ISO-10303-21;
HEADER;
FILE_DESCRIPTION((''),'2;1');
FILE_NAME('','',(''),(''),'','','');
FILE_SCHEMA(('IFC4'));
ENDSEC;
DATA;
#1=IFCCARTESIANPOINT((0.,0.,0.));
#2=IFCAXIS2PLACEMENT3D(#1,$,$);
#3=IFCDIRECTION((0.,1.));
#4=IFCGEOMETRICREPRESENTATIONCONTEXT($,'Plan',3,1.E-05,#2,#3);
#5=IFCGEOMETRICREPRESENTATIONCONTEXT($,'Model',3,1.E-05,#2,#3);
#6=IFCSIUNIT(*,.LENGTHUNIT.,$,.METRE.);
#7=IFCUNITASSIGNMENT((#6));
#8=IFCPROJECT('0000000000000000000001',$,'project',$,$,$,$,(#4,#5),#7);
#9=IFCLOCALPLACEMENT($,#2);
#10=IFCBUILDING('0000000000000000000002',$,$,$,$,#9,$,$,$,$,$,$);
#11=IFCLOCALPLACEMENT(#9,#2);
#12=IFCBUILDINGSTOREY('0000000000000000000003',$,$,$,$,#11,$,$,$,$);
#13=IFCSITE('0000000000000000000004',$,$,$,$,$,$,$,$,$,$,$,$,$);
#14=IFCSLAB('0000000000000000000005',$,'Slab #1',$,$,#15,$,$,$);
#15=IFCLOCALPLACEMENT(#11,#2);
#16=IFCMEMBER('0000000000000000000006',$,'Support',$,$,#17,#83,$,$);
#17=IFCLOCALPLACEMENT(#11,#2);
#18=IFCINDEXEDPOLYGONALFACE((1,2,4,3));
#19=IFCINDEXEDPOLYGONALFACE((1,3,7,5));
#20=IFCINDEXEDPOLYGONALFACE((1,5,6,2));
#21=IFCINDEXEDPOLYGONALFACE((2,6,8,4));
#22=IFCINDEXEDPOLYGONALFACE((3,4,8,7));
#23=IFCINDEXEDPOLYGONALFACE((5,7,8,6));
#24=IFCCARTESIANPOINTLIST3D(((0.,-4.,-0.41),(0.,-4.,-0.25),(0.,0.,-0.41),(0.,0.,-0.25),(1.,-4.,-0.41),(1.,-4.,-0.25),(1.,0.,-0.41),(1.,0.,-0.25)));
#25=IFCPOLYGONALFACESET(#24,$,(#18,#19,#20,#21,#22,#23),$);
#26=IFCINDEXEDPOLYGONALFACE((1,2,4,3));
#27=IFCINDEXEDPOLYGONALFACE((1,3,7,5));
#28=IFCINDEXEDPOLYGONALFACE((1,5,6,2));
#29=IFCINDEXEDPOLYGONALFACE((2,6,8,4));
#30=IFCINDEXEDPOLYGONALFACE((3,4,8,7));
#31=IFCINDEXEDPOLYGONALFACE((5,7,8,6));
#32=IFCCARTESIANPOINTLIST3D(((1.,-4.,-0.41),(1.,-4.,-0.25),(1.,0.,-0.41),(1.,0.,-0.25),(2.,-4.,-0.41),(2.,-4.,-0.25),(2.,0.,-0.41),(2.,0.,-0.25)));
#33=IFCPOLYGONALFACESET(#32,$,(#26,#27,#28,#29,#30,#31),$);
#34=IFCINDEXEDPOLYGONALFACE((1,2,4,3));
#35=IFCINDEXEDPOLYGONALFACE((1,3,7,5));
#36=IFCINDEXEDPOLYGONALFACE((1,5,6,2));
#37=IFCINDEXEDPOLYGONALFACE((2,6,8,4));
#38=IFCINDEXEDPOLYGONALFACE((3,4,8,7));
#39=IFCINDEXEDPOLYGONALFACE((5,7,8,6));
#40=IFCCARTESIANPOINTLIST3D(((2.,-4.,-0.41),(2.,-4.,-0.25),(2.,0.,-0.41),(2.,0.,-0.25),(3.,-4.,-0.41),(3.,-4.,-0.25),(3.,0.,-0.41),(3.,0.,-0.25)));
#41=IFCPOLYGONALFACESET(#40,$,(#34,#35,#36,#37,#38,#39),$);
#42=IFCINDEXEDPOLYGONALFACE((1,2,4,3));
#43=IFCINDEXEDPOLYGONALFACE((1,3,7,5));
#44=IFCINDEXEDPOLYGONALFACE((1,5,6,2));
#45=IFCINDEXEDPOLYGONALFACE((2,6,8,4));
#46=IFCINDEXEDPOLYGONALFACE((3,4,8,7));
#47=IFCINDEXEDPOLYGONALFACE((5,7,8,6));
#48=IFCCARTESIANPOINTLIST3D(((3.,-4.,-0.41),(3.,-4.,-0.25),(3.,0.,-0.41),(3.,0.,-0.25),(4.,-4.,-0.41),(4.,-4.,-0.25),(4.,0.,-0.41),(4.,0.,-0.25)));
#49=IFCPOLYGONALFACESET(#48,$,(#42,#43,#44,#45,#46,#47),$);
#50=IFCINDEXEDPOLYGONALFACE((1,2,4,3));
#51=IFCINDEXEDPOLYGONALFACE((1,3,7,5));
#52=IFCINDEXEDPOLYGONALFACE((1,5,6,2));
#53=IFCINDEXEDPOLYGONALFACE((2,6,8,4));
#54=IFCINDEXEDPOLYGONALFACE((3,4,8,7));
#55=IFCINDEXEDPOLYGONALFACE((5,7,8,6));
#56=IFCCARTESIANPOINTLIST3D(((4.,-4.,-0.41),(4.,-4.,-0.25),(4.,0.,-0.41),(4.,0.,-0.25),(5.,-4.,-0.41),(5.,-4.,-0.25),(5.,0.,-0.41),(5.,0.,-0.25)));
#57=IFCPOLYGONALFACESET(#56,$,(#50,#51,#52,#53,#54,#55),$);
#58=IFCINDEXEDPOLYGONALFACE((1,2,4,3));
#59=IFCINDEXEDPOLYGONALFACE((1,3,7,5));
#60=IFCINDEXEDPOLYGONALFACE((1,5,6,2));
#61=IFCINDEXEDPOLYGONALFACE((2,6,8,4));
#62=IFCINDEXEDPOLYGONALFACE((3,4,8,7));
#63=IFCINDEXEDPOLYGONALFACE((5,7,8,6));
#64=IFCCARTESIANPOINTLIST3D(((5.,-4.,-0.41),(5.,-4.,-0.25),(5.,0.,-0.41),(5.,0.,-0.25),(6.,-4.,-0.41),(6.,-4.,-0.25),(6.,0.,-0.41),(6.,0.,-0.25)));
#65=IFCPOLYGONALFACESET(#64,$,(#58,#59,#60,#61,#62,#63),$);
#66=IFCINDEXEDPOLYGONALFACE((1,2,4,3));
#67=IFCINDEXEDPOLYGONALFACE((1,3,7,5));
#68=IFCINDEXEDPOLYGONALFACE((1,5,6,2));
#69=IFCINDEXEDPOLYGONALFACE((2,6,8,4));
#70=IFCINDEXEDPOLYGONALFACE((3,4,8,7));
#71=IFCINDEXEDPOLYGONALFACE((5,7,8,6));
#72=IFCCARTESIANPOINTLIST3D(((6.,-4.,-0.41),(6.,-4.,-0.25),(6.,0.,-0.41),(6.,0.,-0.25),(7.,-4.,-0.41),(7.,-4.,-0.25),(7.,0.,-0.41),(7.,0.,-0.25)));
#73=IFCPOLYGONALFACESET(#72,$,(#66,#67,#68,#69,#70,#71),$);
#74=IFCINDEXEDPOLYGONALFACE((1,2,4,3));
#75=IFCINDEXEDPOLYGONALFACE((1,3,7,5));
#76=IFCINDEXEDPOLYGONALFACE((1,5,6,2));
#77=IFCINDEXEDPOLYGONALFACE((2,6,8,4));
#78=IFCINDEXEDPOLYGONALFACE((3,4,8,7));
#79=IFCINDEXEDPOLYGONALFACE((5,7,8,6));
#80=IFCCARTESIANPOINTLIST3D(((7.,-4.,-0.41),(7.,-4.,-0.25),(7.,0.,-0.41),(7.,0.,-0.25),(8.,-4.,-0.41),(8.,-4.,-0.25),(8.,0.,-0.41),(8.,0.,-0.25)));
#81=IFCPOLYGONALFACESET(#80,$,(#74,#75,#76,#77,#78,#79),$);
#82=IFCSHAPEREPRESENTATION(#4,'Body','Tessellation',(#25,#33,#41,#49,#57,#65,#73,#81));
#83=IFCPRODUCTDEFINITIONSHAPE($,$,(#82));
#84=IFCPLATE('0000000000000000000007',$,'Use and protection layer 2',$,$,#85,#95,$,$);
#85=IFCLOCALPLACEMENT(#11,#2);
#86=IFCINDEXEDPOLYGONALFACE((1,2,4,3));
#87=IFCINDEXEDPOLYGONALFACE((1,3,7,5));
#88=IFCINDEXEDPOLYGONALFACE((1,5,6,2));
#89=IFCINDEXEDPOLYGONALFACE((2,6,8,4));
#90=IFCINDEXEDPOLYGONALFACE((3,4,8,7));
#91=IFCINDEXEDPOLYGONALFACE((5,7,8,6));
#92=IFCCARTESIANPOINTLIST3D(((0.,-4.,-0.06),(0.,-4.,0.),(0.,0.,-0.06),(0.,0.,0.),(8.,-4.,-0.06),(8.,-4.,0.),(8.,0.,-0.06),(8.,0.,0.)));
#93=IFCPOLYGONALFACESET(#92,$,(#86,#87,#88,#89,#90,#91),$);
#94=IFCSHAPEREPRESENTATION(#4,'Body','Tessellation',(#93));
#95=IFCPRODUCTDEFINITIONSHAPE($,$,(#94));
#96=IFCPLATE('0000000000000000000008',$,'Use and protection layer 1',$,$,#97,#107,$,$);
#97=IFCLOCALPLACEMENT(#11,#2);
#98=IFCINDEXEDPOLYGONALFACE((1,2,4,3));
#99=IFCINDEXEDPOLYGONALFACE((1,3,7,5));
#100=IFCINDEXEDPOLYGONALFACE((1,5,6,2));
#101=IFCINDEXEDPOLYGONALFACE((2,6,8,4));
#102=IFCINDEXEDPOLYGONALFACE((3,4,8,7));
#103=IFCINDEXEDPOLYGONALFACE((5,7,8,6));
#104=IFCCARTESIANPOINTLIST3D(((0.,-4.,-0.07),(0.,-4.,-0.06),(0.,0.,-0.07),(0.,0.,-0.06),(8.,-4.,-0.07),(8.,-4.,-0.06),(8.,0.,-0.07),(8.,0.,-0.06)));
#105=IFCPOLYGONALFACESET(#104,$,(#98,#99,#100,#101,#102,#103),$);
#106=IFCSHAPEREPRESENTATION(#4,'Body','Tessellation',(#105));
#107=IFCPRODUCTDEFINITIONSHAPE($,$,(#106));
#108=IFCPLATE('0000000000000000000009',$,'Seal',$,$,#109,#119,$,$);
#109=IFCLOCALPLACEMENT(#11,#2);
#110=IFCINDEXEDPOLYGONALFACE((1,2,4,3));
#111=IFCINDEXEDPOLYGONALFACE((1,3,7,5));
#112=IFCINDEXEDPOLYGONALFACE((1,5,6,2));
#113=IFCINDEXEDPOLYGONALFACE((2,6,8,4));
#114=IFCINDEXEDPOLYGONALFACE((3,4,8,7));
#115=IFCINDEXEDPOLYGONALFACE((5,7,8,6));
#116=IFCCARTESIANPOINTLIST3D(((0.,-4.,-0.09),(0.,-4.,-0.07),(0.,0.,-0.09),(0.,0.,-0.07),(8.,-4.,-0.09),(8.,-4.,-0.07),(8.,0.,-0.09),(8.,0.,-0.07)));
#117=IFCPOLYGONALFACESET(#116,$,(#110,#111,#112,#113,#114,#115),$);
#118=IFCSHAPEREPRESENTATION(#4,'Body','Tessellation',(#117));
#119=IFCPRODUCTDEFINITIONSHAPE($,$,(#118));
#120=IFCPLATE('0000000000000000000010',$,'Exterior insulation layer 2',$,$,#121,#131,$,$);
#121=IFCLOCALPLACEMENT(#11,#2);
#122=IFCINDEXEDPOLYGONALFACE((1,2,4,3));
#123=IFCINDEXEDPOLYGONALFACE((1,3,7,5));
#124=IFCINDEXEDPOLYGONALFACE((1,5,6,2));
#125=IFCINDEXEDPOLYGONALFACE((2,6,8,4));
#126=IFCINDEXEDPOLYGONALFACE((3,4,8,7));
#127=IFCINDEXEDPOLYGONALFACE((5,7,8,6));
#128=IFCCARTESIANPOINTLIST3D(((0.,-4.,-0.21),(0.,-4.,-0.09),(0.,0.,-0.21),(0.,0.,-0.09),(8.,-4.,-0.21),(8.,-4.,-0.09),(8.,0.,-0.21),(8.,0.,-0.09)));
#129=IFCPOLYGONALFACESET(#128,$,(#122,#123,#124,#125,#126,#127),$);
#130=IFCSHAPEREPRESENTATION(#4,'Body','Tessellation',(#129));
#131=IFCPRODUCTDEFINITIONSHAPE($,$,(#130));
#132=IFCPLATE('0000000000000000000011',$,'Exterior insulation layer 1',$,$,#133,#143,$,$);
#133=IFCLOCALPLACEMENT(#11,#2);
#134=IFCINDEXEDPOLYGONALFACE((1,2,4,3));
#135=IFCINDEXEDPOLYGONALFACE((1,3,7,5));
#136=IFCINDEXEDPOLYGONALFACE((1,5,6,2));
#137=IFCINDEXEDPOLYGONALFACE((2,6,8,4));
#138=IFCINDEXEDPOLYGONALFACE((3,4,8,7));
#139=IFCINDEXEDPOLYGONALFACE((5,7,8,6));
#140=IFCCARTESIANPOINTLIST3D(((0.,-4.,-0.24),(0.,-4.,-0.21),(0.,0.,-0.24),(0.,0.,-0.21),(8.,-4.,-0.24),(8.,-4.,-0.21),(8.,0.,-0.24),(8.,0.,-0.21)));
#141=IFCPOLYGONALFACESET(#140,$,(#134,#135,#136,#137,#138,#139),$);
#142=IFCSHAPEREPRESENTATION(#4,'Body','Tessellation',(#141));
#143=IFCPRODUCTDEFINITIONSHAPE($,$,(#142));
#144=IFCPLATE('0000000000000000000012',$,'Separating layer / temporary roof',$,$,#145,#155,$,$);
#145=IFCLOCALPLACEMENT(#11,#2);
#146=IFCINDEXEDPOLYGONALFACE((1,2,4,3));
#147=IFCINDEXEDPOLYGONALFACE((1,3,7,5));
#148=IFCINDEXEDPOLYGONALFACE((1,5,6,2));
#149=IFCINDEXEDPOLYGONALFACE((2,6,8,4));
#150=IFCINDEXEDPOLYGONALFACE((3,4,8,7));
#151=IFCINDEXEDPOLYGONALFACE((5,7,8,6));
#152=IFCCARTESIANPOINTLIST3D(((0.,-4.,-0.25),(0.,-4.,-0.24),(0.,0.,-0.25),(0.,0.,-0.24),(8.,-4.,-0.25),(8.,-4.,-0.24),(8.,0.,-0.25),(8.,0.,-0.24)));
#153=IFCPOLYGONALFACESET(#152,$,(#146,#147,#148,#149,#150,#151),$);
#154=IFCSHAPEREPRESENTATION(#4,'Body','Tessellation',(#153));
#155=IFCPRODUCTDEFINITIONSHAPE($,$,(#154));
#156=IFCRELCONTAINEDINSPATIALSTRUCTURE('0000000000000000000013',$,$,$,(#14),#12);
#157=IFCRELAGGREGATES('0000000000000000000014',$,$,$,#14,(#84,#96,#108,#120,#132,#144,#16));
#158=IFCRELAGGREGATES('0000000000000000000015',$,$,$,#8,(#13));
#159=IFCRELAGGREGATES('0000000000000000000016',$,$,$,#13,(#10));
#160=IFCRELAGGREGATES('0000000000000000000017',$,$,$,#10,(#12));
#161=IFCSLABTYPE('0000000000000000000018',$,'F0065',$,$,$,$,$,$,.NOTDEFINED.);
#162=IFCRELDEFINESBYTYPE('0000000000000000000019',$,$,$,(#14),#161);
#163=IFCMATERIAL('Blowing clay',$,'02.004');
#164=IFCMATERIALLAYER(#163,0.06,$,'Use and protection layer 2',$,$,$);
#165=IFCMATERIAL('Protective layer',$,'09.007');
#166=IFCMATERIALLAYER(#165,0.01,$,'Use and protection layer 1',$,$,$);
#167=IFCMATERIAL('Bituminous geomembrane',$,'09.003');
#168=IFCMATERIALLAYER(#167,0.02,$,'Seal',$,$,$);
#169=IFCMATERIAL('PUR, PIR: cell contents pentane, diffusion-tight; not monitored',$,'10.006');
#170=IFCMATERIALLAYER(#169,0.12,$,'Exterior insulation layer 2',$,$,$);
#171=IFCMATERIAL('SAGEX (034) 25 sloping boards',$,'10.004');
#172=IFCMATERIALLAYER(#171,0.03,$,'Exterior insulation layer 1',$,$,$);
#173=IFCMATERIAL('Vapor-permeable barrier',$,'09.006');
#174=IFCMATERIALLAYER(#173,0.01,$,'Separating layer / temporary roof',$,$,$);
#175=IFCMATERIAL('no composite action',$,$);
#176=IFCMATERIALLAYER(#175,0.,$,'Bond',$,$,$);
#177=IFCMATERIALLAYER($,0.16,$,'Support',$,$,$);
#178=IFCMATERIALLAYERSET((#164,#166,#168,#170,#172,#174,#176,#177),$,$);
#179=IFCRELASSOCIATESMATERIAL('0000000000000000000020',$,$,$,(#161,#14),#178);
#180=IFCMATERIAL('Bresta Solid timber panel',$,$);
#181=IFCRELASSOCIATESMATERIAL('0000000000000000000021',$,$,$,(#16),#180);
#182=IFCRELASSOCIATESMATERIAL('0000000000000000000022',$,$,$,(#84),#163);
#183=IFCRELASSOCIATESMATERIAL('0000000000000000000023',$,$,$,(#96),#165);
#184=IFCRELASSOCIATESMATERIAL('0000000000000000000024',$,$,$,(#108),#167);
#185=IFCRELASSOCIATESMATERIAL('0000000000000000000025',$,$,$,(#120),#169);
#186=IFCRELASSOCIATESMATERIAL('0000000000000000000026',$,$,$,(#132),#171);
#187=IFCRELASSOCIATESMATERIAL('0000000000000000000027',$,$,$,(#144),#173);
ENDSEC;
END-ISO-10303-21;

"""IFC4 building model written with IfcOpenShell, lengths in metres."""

from ifc_helpers import new_model, si_unit, direction, frame, frame_2d, origin, origin_with_axes, place, context, project, spatial, rectangle, extrude, material, layer, layer_set, type_object, element, aggregate, save


model = new_model("IFC4")

# Units and contexts
plan_context = context("Plan", 3, precision=1e-05, world=origin(), true_north=direction((0.0, 1.0)))
model_context = context("Model", 3, precision=1e-05, world=origin(), true_north=direction((0.0, 1.0)))
ifc_project = project(units=[si_unit("LENGTHUNIT", "METRE")], contexts=[plan_context, model_context])

# Site, building, storey
site = spatial("IfcSite", under=ifc_project)
building_placement = place(None, origin())
building = spatial("IfcBuilding", under=site, at=building_placement)
storey_placement = place(building_placement, origin())
storey = spatial("IfcBuildingStorey", under=building, at=storey_placement)

# Slab, member, plates
ifc_material_1 = material(Name="Blowing clay", Category="02.004")
ifc_layer_1 = layer(ifc_material_1, 0.06, Name="Use and protection layer 2")
ifc_material_2 = material(Name="Protective layer", Category="09.007")
ifc_layer_2 = layer(ifc_material_2, 0.01, Name="Use and protection layer 1")
ifc_material_3 = material(Name="Bituminous geomembrane", Category="09.003")
ifc_layer_3 = layer(ifc_material_3, 0.02, Name="Seal")
ifc_material_4 = material(Name="PUR, PIR: cell contents pentane, diffusion-tight; not monitored", Category="10.006")
ifc_layer_4 = layer(ifc_material_4, 0.12, Name="Exterior insulation layer 2")
ifc_material_5 = material(Name="SAGEX (034) 25 sloping boards", Category="10.004")
ifc_layer_5 = layer(ifc_material_5, 0.03, Name="Exterior insulation layer 1")
ifc_material_6 = material(Name="Vapor-permeable barrier", Category="09.006")
ifc_layer_6 = layer(ifc_material_6, 0.01, Name="Separating layer / temporary roof")
ifc_material_7 = material(Name="no composite action")
ifc_layer_7 = layer(ifc_material_7, 0.0, Name="Bond")
ifc_layer_8 = layer(None, 0.16, Name="Support")
ifc_layer_set = layer_set([ifc_layer_1, ifc_layer_2, ifc_layer_3, ifc_layer_4, ifc_layer_5, ifc_layer_6, ifc_layer_7, ifc_layer_8])
slab_type = type_object("IfcSlabType", Name="F0065", PredefinedType="NOTDEFINED", material=ifc_layer_set)
slab_placement = place(None, frame((0.0, 0.0, 0.0), z_axis=(0.0, 0.0, -1.0), x_axis=(1.0, 0.0, 0.0)))
slab = element("IfcSlab", 1, at=slab_placement, inside=storey, type_object=slab_type, material=ifc_layer_set, Name="Slab #1")
ifc_material_8 = material(Name="Bresta Solid timber panel")
member_placement = place(slab_placement, origin())
member = element("IfcMember", 2, at=member_placement, material=ifc_material_8, Name="Support", context=plan_context, shape_type="SweptSolid", body=[
    extrude(rectangle(XDim=1.0, YDim=0.16, at=frame_2d((0.5, 0.08), x_axis=(1.0, 0.0))), frame((0.0, 4.0, 0.25), z_axis=(0.0, -1.0, 0.0), x_axis=(1.0, 0.0, 0.0)), (0.0, 0.0, 1.0), 4.0),
    extrude(rectangle(XDim=1.0, YDim=0.16, at=frame_2d((0.5, 0.08), x_axis=(1.0, 0.0))), frame((1.0, 4.0, 0.25), z_axis=(0.0, -1.0, 0.0), x_axis=(1.0, 0.0, 0.0)), (0.0, 0.0, 1.0), 4.0),
    extrude(rectangle(XDim=1.0, YDim=0.16, at=frame_2d((0.5, 0.08), x_axis=(1.0, 0.0))), frame((2.0, 4.0, 0.25), z_axis=(0.0, -1.0, 0.0), x_axis=(1.0, 0.0, 0.0)), (0.0, 0.0, 1.0), 4.0),
    extrude(rectangle(XDim=1.0, YDim=0.16, at=frame_2d((0.5, 0.08), x_axis=(1.0, 0.0))), frame((3.0, 4.0, 0.25), z_axis=(0.0, -1.0, 0.0), x_axis=(1.0, 0.0, 0.0)), (0.0, 0.0, 1.0), 4.0),
    extrude(rectangle(XDim=1.0, YDim=0.16, at=frame_2d((0.5, 0.08), x_axis=(1.0, 0.0))), frame((4.0, 4.0, 0.25), z_axis=(0.0, -1.0, 0.0), x_axis=(1.0, 0.0, 0.0)), (0.0, 0.0, 1.0), 4.0),
    extrude(rectangle(XDim=1.0, YDim=0.16, at=frame_2d((0.5, 0.08), x_axis=(1.0, 0.0))), frame((5.0, 4.0, 0.25), z_axis=(0.0, -1.0, 0.0), x_axis=(1.0, 0.0, 0.0)), (0.0, 0.0, 1.0), 4.0),
    extrude(rectangle(XDim=1.0, YDim=0.16, at=frame_2d((0.5, 0.08), x_axis=(1.0, 0.0))), frame((6.0, 4.0, 0.25), z_axis=(0.0, -1.0, 0.0), x_axis=(1.0, 0.0, 0.0)), (0.0, 0.0, 1.0), 4.0),
    extrude(rectangle(XDim=1.0, YDim=0.16, at=frame_2d((0.5, 0.08), x_axis=(1.0, 0.0))), frame((7.0, 4.0, 0.25), z_axis=(0.0, -1.0, 0.0), x_axis=(1.0, 0.0, 0.0)), (0.0, 0.0, 1.0), 4.0),
])
plate_1_placement = place(slab_placement, origin())
plate_1 = element("IfcPlate", 3, at=plate_1_placement, material=ifc_material_1, Name="Use and protection layer 2", context=plan_context, shape_type="SweptSolid", body=[
    extrude(rectangle(XDim=8.0, YDim=4.0, at=frame_2d((4.0, 2.0), x_axis=(1.0, 0.0))), origin_with_axes(), (0.0, 0.0, 1.0), 0.06),
])
plate_2_placement = place(slab_placement, origin())
plate_2 = element("IfcPlate", 4, at=plate_2_placement, material=ifc_material_2, Name="Use and protection layer 1", context=plan_context, shape_type="SweptSolid", body=[
    extrude(rectangle(XDim=8.0, YDim=4.0, at=frame_2d((4.0, 2.0), x_axis=(1.0, 0.0))), frame((0.0, 0.0, 0.06), z_axis=(0.0, 0.0, 1.0), x_axis=(1.0, 0.0, 0.0)), (0.0, 0.0, 1.0), 0.01),
])
plate_3_placement = place(slab_placement, origin())
plate_3 = element("IfcPlate", 5, at=plate_3_placement, material=ifc_material_3, Name="Seal", context=plan_context, shape_type="SweptSolid", body=[
    extrude(rectangle(XDim=8.0, YDim=4.0, at=frame_2d((4.0, 2.0), x_axis=(1.0, 0.0))), frame((0.0, 0.0, 0.07), z_axis=(0.0, 0.0, 1.0), x_axis=(1.0, 0.0, 0.0)), (0.0, 0.0, 1.0), 0.02),
])
plate_4_placement = place(slab_placement, origin())
plate_4 = element("IfcPlate", 6, at=plate_4_placement, material=ifc_material_4, Name="Exterior insulation layer 2", context=plan_context, shape_type="SweptSolid", body=[
    extrude(rectangle(XDim=8.0, YDim=4.0, at=frame_2d((4.0, 2.0), x_axis=(1.0, 0.0))), frame((0.0, 0.0, 0.09), z_axis=(0.0, 0.0, 1.0), x_axis=(1.0, 0.0, 0.0)), (0.0, 0.0, 1.0), 0.12),
])
plate_5_placement = place(slab_placement, origin())
plate_5 = element("IfcPlate", 7, at=plate_5_placement, material=ifc_material_5, Name="Exterior insulation layer 1", context=plan_context, shape_type="SweptSolid", body=[
    extrude(rectangle(XDim=8.0, YDim=4.0, at=frame_2d((4.0, 2.0), x_axis=(1.0, 0.0))), frame((0.0, 0.0, 0.21), z_axis=(0.0, 0.0, 1.0), x_axis=(1.0, 0.0, 0.0)), (0.0, 0.0, 1.0), 0.03),
])
plate_6_placement = place(slab_placement, origin())
plate_6 = element("IfcPlate", 8, at=plate_6_placement, material=ifc_material_6, Name="Separating layer / temporary roof", context=plan_context, shape_type="SweptSolid", body=[
    extrude(rectangle(XDim=8.0, YDim=4.0, at=frame_2d((4.0, 2.0), x_axis=(1.0, 0.0))), frame((0.0, 0.0, 0.24), z_axis=(0.0, 0.0, 1.0), x_axis=(1.0, 0.0, 0.0)), (0.0, 0.0, 1.0), 0.01),
])
aggregate(slab, [plate_1, plate_2, plate_3, plate_4, plate_5, plate_6, member])

save(model, "model.ifc")
